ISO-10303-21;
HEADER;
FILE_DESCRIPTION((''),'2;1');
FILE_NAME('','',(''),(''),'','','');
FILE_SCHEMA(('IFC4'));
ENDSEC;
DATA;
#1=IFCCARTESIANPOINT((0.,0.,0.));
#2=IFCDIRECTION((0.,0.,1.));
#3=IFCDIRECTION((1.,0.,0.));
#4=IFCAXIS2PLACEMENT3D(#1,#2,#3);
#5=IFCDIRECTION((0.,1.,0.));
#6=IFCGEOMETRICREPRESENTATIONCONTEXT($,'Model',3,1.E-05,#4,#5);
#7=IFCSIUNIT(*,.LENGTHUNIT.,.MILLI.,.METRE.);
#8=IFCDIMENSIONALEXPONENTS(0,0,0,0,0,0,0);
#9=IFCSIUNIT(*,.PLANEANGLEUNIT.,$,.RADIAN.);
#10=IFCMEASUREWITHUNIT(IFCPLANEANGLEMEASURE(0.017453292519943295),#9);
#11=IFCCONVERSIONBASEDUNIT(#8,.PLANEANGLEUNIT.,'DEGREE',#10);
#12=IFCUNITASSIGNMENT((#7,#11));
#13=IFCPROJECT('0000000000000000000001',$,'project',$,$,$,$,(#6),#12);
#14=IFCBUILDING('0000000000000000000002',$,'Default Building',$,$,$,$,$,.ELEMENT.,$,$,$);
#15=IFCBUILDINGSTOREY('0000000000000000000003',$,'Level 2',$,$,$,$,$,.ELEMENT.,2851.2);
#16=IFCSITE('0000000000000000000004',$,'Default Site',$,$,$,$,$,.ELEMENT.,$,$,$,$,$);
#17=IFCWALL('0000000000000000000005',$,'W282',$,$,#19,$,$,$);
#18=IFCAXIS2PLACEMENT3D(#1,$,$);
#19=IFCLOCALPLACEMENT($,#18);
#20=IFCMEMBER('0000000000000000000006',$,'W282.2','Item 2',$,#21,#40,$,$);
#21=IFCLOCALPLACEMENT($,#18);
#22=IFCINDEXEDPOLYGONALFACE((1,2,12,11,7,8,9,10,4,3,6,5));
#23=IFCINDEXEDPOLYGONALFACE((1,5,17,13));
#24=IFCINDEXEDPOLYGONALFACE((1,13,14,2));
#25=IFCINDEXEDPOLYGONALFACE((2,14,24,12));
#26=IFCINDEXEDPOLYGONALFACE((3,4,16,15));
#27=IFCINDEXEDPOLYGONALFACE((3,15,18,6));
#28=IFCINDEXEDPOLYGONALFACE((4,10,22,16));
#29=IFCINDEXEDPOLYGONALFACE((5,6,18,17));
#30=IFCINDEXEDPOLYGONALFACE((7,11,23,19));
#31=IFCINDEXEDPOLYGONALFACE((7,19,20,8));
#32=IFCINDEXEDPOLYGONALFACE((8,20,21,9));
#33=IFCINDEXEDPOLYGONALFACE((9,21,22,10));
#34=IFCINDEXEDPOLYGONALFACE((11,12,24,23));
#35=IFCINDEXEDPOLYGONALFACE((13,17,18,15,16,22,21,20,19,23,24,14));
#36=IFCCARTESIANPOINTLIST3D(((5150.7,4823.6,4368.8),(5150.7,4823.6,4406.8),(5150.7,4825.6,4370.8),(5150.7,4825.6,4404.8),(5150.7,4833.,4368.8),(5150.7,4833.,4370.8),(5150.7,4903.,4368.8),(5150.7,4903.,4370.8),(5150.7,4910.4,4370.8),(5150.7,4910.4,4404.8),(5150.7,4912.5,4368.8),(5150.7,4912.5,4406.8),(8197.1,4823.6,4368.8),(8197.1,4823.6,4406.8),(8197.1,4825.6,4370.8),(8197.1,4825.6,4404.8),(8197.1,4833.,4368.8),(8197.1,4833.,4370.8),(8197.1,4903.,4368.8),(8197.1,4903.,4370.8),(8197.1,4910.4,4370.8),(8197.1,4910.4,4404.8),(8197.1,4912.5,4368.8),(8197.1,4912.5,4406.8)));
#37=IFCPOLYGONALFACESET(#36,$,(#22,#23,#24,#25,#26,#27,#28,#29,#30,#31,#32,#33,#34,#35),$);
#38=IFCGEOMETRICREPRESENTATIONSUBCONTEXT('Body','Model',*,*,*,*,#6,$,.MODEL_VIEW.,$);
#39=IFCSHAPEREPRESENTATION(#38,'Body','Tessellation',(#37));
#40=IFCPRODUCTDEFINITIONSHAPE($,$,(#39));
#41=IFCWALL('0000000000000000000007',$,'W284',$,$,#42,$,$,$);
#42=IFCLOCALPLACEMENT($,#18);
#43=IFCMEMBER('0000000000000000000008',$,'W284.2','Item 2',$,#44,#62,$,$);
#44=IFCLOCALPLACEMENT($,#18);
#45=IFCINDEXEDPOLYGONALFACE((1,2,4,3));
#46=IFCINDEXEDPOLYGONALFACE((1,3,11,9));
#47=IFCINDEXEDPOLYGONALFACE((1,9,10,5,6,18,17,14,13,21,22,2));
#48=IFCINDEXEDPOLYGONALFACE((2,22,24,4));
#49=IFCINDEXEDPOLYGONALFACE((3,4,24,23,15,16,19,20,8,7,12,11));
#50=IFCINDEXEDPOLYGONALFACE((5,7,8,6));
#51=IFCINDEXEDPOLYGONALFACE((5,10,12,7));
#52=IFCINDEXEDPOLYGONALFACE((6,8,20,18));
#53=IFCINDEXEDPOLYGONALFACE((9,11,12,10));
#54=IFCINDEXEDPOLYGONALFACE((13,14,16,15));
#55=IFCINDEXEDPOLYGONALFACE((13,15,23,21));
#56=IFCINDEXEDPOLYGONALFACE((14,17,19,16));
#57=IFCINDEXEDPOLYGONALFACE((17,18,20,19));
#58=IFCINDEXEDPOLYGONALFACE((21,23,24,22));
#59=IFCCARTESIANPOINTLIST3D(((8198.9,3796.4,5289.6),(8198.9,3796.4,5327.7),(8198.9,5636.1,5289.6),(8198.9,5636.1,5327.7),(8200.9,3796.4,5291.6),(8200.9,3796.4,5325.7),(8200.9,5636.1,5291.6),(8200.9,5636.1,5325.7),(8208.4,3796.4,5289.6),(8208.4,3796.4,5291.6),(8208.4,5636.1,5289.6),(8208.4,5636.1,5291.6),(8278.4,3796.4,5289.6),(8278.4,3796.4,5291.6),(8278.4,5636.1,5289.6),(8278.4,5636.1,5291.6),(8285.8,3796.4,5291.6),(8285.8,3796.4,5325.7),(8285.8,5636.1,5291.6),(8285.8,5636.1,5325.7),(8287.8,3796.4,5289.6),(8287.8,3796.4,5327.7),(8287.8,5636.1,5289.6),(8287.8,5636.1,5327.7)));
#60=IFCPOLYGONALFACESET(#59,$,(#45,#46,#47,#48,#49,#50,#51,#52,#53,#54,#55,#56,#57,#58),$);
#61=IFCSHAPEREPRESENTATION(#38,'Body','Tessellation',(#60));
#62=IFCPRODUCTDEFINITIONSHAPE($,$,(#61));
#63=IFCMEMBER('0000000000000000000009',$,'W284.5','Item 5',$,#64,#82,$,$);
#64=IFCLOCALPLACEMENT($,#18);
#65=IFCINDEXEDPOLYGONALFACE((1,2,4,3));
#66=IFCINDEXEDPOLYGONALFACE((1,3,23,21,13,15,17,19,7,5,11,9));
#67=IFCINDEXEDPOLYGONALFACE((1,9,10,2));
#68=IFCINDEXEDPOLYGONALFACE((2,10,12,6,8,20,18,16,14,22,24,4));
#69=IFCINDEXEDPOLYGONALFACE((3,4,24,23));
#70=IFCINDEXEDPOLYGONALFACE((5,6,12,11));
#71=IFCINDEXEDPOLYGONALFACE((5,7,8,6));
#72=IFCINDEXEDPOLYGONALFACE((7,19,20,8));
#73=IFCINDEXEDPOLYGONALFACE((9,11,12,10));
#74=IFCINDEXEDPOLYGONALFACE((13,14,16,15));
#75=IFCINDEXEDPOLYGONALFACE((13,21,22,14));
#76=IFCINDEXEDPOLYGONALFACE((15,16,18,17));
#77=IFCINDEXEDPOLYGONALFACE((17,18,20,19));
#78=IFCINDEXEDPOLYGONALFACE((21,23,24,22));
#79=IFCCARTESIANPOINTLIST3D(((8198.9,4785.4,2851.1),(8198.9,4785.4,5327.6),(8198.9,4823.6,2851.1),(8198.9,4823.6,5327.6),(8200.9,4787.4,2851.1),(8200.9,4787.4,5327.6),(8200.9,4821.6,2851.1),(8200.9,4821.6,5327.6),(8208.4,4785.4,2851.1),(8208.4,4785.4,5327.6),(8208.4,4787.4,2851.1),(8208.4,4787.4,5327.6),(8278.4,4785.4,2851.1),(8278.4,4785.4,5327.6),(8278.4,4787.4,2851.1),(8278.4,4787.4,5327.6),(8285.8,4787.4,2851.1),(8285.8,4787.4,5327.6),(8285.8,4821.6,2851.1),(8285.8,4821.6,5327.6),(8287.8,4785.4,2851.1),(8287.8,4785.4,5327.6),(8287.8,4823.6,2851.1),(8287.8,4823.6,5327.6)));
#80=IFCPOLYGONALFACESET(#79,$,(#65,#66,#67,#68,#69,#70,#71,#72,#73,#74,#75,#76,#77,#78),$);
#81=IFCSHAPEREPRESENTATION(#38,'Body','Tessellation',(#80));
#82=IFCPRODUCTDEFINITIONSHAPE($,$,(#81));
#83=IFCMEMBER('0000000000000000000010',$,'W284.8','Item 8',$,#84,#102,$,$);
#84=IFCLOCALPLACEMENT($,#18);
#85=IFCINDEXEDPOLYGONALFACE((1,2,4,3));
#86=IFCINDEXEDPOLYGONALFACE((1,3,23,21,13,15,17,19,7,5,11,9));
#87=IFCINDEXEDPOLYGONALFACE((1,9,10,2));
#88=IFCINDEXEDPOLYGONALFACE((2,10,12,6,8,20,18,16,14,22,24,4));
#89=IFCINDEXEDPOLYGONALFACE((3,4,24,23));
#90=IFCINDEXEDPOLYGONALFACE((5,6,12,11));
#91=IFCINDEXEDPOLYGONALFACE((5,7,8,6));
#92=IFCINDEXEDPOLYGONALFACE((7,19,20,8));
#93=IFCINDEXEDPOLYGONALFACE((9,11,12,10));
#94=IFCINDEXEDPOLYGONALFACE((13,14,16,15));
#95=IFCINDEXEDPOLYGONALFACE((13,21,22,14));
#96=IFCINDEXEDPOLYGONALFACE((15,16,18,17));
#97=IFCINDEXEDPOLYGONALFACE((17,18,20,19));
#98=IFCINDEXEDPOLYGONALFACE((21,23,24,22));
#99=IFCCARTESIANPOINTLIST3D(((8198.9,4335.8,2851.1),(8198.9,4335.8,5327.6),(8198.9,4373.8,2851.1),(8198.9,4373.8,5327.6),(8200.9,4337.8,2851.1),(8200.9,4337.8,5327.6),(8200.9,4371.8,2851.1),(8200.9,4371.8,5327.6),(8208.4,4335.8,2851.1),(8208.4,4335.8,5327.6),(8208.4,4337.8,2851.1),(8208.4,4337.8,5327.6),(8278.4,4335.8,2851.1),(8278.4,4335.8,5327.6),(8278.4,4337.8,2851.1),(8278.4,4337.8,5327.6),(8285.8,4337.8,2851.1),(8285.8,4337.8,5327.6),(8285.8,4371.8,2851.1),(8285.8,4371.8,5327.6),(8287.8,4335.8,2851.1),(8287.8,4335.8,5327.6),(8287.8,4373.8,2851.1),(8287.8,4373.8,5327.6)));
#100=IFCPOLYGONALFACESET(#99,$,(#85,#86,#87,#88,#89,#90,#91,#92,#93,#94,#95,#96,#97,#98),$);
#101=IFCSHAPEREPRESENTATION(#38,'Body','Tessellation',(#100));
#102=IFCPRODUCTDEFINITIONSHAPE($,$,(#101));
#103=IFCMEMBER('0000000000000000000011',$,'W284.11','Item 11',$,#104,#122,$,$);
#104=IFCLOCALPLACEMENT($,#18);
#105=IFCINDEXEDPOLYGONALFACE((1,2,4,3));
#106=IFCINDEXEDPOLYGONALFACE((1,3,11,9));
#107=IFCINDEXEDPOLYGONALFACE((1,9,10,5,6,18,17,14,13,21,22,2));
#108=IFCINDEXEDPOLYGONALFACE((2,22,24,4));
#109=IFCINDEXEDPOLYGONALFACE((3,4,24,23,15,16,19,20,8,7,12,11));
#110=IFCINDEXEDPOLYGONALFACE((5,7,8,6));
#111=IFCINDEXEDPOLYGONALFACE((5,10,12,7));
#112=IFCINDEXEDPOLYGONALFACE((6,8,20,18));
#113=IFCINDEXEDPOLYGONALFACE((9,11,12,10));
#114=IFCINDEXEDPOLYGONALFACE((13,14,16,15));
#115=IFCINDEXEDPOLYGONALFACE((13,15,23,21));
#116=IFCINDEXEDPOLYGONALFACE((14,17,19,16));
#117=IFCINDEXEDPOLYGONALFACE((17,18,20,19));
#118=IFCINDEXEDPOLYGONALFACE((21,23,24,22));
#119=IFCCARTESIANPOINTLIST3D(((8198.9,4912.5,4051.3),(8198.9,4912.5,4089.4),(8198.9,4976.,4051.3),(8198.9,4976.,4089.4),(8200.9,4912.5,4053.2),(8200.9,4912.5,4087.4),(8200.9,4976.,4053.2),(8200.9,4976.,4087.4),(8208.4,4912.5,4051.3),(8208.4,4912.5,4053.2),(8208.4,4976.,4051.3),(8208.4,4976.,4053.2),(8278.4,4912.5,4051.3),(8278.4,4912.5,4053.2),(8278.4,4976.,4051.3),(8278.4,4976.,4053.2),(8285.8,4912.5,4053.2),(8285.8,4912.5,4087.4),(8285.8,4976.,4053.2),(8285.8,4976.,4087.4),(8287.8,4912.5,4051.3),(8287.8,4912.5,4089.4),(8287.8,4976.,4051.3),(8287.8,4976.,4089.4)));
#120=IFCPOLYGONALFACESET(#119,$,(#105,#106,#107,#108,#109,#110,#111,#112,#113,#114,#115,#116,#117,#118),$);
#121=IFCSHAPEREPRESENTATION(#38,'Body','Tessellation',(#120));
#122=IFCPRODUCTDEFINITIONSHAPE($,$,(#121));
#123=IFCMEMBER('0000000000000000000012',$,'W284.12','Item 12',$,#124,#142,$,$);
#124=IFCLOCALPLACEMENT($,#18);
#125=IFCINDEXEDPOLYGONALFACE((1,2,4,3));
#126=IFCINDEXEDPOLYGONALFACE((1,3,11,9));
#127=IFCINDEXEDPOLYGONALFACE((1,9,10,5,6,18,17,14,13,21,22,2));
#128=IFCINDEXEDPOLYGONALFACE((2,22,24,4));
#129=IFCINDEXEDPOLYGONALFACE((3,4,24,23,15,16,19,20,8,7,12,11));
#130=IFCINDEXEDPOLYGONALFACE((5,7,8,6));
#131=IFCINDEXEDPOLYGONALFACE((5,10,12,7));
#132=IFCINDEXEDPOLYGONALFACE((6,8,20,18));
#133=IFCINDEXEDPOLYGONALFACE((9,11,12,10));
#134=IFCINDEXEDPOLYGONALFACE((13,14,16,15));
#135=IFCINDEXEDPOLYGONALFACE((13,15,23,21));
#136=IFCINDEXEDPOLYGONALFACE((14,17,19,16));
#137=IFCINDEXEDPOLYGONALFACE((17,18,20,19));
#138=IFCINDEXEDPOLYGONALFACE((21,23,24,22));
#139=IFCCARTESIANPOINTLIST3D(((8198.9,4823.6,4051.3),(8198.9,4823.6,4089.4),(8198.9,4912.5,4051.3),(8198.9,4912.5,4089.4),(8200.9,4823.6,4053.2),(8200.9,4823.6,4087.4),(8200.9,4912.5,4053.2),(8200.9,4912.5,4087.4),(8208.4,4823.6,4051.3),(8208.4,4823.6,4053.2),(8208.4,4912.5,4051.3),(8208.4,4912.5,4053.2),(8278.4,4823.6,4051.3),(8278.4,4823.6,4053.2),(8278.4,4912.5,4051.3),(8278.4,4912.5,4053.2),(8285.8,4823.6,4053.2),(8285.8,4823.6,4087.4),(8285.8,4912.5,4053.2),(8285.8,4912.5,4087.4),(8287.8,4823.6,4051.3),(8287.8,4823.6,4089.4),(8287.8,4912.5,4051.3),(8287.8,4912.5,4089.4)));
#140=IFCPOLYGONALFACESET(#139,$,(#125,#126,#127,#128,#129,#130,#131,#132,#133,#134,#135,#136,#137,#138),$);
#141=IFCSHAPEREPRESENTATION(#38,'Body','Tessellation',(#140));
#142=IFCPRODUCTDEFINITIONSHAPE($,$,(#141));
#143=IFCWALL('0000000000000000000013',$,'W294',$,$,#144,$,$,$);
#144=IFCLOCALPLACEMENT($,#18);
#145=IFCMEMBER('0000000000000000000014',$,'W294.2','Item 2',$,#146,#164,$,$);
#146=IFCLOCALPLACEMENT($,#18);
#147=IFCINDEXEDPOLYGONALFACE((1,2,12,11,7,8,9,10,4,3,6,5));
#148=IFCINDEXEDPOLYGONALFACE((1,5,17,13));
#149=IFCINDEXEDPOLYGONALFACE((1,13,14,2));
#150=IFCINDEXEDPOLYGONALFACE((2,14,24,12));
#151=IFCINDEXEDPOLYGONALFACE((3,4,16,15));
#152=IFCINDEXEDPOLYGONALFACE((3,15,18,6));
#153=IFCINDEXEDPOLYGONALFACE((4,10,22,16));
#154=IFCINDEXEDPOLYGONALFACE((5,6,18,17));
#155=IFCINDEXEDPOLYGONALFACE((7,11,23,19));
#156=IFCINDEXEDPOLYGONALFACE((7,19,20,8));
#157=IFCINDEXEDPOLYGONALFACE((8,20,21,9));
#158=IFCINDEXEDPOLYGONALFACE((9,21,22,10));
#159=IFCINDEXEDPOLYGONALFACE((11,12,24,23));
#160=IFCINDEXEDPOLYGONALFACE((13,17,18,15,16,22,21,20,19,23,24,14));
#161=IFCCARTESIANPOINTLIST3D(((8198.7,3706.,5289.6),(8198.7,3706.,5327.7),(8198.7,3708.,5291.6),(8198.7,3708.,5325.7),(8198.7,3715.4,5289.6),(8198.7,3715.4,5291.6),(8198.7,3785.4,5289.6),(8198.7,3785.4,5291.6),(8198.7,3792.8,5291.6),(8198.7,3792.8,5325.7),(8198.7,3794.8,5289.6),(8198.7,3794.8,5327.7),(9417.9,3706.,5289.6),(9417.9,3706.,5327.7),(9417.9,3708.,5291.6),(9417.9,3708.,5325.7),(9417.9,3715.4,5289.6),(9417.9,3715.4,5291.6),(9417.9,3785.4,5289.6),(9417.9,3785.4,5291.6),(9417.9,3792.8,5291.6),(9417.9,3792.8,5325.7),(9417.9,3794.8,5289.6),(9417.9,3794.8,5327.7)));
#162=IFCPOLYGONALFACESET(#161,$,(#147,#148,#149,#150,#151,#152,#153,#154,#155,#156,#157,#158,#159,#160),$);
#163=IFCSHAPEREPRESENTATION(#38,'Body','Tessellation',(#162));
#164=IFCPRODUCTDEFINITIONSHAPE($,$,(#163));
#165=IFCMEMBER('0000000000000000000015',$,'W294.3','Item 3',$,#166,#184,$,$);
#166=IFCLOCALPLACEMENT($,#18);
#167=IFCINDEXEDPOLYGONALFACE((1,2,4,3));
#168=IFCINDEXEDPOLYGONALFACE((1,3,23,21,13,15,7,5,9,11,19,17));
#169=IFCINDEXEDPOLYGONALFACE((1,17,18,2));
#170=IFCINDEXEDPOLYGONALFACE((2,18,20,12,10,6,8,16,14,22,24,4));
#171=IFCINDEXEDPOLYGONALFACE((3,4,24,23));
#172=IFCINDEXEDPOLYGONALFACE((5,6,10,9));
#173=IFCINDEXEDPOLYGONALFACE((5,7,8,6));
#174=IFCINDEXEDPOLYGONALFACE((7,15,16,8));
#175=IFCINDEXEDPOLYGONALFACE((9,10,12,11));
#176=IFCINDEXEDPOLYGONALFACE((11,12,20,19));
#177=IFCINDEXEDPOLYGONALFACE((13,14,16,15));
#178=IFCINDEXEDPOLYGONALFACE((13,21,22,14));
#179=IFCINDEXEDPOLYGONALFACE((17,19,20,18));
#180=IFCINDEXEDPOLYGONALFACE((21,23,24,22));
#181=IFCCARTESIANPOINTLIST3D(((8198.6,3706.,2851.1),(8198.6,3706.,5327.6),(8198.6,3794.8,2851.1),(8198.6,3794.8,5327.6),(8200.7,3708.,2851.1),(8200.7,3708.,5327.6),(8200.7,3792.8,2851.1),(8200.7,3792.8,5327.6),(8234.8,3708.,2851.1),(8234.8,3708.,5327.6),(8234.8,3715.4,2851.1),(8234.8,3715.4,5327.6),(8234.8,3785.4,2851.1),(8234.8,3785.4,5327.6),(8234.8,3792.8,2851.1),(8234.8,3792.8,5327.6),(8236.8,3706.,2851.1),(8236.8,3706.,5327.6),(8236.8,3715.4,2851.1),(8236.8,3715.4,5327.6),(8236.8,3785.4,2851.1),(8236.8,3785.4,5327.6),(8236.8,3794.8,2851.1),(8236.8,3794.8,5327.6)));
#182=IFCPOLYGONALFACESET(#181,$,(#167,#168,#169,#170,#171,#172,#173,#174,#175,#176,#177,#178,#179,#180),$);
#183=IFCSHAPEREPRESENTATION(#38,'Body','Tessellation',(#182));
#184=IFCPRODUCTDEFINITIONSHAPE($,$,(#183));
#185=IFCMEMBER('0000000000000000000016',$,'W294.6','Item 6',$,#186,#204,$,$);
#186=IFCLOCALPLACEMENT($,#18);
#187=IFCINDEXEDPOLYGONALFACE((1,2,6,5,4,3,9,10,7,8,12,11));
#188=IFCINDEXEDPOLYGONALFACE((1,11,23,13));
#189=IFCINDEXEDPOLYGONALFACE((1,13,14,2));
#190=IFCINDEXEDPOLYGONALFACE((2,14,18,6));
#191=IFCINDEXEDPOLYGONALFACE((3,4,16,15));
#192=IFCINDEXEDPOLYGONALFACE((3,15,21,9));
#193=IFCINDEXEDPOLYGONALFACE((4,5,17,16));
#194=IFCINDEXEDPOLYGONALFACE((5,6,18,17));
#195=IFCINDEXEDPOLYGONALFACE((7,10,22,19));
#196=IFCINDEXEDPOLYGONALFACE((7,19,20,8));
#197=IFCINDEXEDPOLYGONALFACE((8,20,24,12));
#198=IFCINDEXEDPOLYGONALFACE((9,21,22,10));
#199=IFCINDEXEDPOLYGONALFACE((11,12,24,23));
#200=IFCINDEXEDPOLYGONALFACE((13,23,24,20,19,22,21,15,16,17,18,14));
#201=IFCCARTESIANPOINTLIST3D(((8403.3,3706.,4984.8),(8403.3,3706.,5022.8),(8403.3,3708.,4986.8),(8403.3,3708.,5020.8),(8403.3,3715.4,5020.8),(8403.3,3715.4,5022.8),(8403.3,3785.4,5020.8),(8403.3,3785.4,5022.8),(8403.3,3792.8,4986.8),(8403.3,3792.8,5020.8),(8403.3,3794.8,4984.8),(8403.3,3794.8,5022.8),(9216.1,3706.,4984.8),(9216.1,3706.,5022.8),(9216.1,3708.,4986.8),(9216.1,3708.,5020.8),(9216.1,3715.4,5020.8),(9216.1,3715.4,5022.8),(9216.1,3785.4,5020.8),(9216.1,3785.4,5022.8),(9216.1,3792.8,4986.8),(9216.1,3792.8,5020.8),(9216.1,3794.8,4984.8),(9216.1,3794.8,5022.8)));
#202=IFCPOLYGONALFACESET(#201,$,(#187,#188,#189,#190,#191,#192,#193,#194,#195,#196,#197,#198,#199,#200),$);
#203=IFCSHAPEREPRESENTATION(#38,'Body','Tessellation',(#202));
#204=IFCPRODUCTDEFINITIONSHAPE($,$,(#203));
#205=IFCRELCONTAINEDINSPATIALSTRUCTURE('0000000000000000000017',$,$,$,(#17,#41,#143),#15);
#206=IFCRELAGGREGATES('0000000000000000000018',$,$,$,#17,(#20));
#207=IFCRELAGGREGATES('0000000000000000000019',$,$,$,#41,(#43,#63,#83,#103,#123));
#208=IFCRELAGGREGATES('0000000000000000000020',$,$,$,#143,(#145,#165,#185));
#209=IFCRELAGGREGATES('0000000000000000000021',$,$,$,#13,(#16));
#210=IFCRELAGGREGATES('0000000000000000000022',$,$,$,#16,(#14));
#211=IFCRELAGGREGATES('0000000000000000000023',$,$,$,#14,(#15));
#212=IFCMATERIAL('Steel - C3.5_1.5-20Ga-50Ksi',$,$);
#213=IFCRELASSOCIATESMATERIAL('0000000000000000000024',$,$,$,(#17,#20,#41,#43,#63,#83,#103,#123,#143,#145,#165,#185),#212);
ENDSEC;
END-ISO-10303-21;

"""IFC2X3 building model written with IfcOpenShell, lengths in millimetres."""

from ifc_helpers import new_model, entity, si_unit, converted_unit, direction, frame, origin, origin_with_axes, origin_2d_with_axis, place, context, subcontext, project, spatial, c_section, extrude, material, element, aggregate, save


model = new_model("IFC2X3")

# Units and contexts
model_context = context("Model", 3, precision=1e-05, world=origin_with_axes(), true_north=direction((0.0, 1.0, 0.0)))
body_context = subcontext(model_context, "Body", "Model", "MODEL_VIEW")
ifc_project = project(units=[si_unit("LENGTHUNIT", "METRE", prefix="MILLI"), converted_unit("PLANEANGLEUNIT", "DEGREE", entity("IfcPlaneAngleMeasure", 0.017453292519943295), si_unit("PLANEANGLEUNIT", "RADIAN"), dimensions=[0, 0, 0, 0, 0, 0, 0])], contexts=[model_context])

# Site, building, storey
site = spatial("IfcSite", under=ifc_project, Name="Default Site", CompositionType="ELEMENT")
building = spatial("IfcBuilding", under=site, Name="Default Building", CompositionType="ELEMENT")
storey = spatial("IfcBuildingStorey", under=building, Name="Level 2", CompositionType="ELEMENT", Elevation=2851.2)

# Wall, member
ifc_material_1 = material(Name="Steel - C3.5_1.5-20Ga-50Ksi")
wall_1 = element("IfcWall", 1, inside=storey, material=ifc_material_1, Name="W282")
member_1_placement = place(None, frame((8197.1, 4868.0, 4387.8), z_axis=(-1.0, 0.0, 0.0), x_axis=(0.0, 0.0, -1.0)))
member_1 = element("IfcMember", 2, at=member_1_placement, material=ifc_material_1, Name="W282.2", Description="Item 2", context=body_context, shape_type="SweptSolid", body=[
    extrude(c_section(Depth=88.9, Width=38.1, WallThickness=2.0, Girth=9.5, at=origin_2d_with_axis()), origin(), (0.0, 0.0, 1.0), 3046.4),
])
aggregate(wall_1, [member_1])

# Walls, members
wall_2 = element("IfcWall", 3, inside=storey, material=ifc_material_1, Name="W284")
member_2_placement = place(None, frame((8243.4, 3796.4, 5308.6), z_axis=(0.0, 1.0, 0.0), x_axis=(0.0, 0.0, -1.0)))
member_2 = element("IfcMember", 4, at=member_2_placement, material=ifc_material_1, Name="W284.2", Description="Item 2", context=body_context, shape_type="SweptSolid", body=[
    extrude(c_section(Depth=88.9, Width=38.1, WallThickness=2.0, Girth=9.5, at=origin_2d_with_axis()), origin(), (0.0, 0.0, 1.0), 1839.7),
])
member_3_placement = place(None, frame((8243.4, 4804.5, 5327.6), z_axis=(0.0, 0.0, -1.0), x_axis=(0.0, -1.0, 0.0)))
member_3 = element("IfcMember", 5, at=member_3_placement, material=ifc_material_1, Name="W284.5", Description="Item 5", context=body_context, shape_type="SweptSolid", body=[
    extrude(c_section(Depth=88.9, Width=38.1, WallThickness=2.0, Girth=9.5, at=origin_2d_with_axis()), origin(), (0.0, 0.0, 1.0), 2476.5),
])
member_4_placement = place(None, frame((8243.4, 4354.8, 5327.6), z_axis=(0.0, 0.0, -1.0), x_axis=(0.0, -1.0, 0.0)))
member_4 = element("IfcMember", 6, at=member_4_placement, material=ifc_material_1, Name="W284.8", Description="Item 8", context=body_context, shape_type="SweptSolid", body=[
    extrude(c_section(Depth=88.9, Width=38.1, WallThickness=2.0, Girth=9.5, at=origin_2d_with_axis()), origin(), (0.0, 0.0, 1.0), 2476.5),
])
member_5_placement = place(None, frame((8243.4, 4912.5, 4070.3), z_axis=(0.0, 1.0, 0.0), x_axis=(0.0, 0.0, -1.0)))
member_5 = element("IfcMember", 7, at=member_5_placement, material=ifc_material_1, Name="W284.11", Description="Item 11", context=body_context, shape_type="SweptSolid", body=[
    extrude(c_section(Depth=88.9, Width=38.1, WallThickness=2.0, Girth=9.5, at=origin_2d_with_axis()), origin(), (0.0, 0.0, 1.0), 63.5),
])
member_6_placement = place(None, frame((8243.4, 4823.6, 4070.3), z_axis=(0.0, 1.0, 0.0), x_axis=(0.0, 0.0, -1.0)))
member_6 = element("IfcMember", 8, at=member_6_placement, material=ifc_material_1, Name="W284.12", Description="Item 12", context=body_context, shape_type="SweptSolid", body=[
    extrude(c_section(Depth=88.9, Width=38.1, WallThickness=2.0, Girth=9.5, at=origin_2d_with_axis()), origin(), (0.0, 0.0, 1.0), 88.9),
])
aggregate(wall_2, [member_2, member_3, member_4, member_5, member_6])
wall_3 = element("IfcWall", 9, inside=storey, material=ifc_material_1, Name="W294")
member_7_placement = place(None, frame((9417.9, 3750.4, 5308.6), z_axis=(-1.0, 0.0, 0.0), x_axis=(0.0, 0.0, -1.0)))
member_7 = element("IfcMember", 10, at=member_7_placement, material=ifc_material_1, Name="W294.2", Description="Item 2", context=body_context, shape_type="SweptSolid", body=[
    extrude(c_section(Depth=88.9, Width=38.1, WallThickness=2.0, Girth=9.5, at=origin_2d_with_axis()), origin(), (0.0, 0.0, 1.0), 1219.2),
])
member_8_placement = place(None, frame((8217.7, 3750.4, 5327.6), z_axis=(0.0, 0.0, -1.0), x_axis=(1.0, 0.0, 0.0)))
member_8 = element("IfcMember", 11, at=member_8_placement, material=ifc_material_1, Name="W294.3", Description="Item 3", context=body_context, shape_type="SweptSolid", body=[
    extrude(c_section(Depth=88.9, Width=38.1, WallThickness=2.0, Girth=9.5, at=origin_2d_with_axis()), origin(), (0.0, 0.0, 1.0), 2476.5),
])
member_9_placement = place(None, frame((8403.3, 3750.4, 5003.8), z_axis=(1.0, 0.0, 0.0), x_axis=(0.0, 0.0, 1.0)))
member_9 = element("IfcMember", 12, at=member_9_placement, material=ifc_material_1, Name="W294.6", Description="Item 6", context=body_context, shape_type="SweptSolid", body=[
    extrude(c_section(Depth=88.9, Width=38.1, WallThickness=2.0, Girth=9.5, at=origin_2d_with_axis()), origin(), (0.0, 0.0, 1.0), 812.8),
])
aggregate(wall_3, [member_7, member_8, member_9])

save(model, "model.ifc")
